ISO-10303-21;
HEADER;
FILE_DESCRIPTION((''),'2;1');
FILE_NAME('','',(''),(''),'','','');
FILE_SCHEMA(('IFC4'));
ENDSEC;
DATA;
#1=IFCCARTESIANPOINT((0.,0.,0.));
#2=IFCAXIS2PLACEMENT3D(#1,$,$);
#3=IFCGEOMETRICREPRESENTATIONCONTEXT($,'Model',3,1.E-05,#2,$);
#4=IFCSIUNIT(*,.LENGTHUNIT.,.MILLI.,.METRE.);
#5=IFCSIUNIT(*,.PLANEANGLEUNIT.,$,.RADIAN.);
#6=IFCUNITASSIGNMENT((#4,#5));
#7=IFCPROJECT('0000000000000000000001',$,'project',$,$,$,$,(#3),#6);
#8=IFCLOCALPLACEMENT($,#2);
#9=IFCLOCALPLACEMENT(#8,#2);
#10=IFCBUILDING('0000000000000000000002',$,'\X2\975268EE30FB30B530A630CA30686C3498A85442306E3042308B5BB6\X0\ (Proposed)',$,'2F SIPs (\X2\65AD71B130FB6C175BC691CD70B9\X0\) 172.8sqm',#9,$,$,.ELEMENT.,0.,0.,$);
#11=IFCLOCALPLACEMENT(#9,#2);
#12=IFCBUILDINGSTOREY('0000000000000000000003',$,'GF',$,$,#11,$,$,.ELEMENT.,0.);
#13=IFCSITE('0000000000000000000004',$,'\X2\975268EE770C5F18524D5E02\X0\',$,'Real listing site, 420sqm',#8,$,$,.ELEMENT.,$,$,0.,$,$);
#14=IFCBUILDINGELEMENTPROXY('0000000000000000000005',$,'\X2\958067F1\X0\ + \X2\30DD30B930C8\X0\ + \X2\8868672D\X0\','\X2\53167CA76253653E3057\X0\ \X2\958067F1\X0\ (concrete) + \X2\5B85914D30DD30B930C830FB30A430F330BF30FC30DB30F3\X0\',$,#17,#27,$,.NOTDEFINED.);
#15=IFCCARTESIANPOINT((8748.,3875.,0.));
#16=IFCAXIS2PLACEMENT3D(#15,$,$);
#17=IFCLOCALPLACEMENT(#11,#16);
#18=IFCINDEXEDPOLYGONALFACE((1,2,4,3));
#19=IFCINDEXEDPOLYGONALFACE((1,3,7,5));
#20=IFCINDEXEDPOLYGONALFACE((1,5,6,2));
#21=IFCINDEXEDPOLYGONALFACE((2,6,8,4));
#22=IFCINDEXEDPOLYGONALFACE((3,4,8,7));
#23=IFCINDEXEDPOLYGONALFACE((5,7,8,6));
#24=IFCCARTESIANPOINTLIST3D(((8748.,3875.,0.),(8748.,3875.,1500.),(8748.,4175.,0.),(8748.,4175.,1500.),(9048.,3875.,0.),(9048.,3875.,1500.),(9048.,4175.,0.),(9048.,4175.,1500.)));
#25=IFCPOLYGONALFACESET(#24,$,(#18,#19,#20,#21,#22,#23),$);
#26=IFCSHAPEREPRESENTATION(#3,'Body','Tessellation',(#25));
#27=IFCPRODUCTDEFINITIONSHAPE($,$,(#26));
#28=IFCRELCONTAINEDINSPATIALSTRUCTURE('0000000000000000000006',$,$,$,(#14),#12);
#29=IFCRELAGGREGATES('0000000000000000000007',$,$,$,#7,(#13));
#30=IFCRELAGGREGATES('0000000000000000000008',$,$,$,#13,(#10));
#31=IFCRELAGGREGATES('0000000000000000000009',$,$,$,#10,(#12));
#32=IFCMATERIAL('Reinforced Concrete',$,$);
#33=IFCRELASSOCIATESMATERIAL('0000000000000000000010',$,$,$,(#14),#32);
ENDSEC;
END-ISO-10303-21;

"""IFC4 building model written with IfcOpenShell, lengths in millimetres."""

from ifc_helpers import new_model, si_unit, frame, frame_2d, origin, place, context, project, spatial, rectangle, extrude, material, element, save


model = new_model("IFC4")

# Units and contexts
model_context = context("Model", 3, precision=1e-05, world=origin())
ifc_project = project(units=[si_unit("LENGTHUNIT", "METRE", prefix="MILLI"), si_unit("PLANEANGLEUNIT", "RADIAN")], contexts=[model_context])

# Site, building, storey
site_placement = place(None, origin())
site = spatial("IfcSite", under=ifc_project, at=site_placement, Name="青森県弘前市", ObjectType="Real listing site, 420sqm", CompositionType="ELEMENT", RefElevation=0.0)
building_placement = place(site_placement, origin())
building = spatial("IfcBuilding", under=site, at=building_placement, Name="青森・サウナと水風呂のある家 (Proposed)", ObjectType="2F SIPs (断熱・気密重点) 172.8sqm", CompositionType="ELEMENT", ElevationOfRefHeight=0.0, ElevationOfTerrain=0.0)
storey_placement = place(building_placement, origin())
storey = spatial("IfcBuildingStorey", under=building, at=storey_placement, Name="GF", CompositionType="ELEMENT", Elevation=0.0)

# Shared definitions
ifc_material_1 = material(Name="Reinforced Concrete")

# Building element proxy
proxy_placement = place(storey_placement, frame((8748.0, 3875.0, 0.0)))
element("IfcBuildingElementProxy", 1, at=proxy_placement, inside=storey, material=ifc_material_1, Name="門柱 + ポスト + 表札", Description="化粧打放し 門柱 (concrete) + 宅配ポスト・インターホン", PredefinedType="NOTDEFINED", context=model_context, shape_type="SweptSolid", body=[
    extrude(rectangle(XDim=300.0, YDim=300.0, at=frame_2d((150.0, 150.0))), frame((8748.0, 3875.0, 0.0)), (0.0, 0.0, 1.0), 1500.0),
])

save(model, "model.ifc")
